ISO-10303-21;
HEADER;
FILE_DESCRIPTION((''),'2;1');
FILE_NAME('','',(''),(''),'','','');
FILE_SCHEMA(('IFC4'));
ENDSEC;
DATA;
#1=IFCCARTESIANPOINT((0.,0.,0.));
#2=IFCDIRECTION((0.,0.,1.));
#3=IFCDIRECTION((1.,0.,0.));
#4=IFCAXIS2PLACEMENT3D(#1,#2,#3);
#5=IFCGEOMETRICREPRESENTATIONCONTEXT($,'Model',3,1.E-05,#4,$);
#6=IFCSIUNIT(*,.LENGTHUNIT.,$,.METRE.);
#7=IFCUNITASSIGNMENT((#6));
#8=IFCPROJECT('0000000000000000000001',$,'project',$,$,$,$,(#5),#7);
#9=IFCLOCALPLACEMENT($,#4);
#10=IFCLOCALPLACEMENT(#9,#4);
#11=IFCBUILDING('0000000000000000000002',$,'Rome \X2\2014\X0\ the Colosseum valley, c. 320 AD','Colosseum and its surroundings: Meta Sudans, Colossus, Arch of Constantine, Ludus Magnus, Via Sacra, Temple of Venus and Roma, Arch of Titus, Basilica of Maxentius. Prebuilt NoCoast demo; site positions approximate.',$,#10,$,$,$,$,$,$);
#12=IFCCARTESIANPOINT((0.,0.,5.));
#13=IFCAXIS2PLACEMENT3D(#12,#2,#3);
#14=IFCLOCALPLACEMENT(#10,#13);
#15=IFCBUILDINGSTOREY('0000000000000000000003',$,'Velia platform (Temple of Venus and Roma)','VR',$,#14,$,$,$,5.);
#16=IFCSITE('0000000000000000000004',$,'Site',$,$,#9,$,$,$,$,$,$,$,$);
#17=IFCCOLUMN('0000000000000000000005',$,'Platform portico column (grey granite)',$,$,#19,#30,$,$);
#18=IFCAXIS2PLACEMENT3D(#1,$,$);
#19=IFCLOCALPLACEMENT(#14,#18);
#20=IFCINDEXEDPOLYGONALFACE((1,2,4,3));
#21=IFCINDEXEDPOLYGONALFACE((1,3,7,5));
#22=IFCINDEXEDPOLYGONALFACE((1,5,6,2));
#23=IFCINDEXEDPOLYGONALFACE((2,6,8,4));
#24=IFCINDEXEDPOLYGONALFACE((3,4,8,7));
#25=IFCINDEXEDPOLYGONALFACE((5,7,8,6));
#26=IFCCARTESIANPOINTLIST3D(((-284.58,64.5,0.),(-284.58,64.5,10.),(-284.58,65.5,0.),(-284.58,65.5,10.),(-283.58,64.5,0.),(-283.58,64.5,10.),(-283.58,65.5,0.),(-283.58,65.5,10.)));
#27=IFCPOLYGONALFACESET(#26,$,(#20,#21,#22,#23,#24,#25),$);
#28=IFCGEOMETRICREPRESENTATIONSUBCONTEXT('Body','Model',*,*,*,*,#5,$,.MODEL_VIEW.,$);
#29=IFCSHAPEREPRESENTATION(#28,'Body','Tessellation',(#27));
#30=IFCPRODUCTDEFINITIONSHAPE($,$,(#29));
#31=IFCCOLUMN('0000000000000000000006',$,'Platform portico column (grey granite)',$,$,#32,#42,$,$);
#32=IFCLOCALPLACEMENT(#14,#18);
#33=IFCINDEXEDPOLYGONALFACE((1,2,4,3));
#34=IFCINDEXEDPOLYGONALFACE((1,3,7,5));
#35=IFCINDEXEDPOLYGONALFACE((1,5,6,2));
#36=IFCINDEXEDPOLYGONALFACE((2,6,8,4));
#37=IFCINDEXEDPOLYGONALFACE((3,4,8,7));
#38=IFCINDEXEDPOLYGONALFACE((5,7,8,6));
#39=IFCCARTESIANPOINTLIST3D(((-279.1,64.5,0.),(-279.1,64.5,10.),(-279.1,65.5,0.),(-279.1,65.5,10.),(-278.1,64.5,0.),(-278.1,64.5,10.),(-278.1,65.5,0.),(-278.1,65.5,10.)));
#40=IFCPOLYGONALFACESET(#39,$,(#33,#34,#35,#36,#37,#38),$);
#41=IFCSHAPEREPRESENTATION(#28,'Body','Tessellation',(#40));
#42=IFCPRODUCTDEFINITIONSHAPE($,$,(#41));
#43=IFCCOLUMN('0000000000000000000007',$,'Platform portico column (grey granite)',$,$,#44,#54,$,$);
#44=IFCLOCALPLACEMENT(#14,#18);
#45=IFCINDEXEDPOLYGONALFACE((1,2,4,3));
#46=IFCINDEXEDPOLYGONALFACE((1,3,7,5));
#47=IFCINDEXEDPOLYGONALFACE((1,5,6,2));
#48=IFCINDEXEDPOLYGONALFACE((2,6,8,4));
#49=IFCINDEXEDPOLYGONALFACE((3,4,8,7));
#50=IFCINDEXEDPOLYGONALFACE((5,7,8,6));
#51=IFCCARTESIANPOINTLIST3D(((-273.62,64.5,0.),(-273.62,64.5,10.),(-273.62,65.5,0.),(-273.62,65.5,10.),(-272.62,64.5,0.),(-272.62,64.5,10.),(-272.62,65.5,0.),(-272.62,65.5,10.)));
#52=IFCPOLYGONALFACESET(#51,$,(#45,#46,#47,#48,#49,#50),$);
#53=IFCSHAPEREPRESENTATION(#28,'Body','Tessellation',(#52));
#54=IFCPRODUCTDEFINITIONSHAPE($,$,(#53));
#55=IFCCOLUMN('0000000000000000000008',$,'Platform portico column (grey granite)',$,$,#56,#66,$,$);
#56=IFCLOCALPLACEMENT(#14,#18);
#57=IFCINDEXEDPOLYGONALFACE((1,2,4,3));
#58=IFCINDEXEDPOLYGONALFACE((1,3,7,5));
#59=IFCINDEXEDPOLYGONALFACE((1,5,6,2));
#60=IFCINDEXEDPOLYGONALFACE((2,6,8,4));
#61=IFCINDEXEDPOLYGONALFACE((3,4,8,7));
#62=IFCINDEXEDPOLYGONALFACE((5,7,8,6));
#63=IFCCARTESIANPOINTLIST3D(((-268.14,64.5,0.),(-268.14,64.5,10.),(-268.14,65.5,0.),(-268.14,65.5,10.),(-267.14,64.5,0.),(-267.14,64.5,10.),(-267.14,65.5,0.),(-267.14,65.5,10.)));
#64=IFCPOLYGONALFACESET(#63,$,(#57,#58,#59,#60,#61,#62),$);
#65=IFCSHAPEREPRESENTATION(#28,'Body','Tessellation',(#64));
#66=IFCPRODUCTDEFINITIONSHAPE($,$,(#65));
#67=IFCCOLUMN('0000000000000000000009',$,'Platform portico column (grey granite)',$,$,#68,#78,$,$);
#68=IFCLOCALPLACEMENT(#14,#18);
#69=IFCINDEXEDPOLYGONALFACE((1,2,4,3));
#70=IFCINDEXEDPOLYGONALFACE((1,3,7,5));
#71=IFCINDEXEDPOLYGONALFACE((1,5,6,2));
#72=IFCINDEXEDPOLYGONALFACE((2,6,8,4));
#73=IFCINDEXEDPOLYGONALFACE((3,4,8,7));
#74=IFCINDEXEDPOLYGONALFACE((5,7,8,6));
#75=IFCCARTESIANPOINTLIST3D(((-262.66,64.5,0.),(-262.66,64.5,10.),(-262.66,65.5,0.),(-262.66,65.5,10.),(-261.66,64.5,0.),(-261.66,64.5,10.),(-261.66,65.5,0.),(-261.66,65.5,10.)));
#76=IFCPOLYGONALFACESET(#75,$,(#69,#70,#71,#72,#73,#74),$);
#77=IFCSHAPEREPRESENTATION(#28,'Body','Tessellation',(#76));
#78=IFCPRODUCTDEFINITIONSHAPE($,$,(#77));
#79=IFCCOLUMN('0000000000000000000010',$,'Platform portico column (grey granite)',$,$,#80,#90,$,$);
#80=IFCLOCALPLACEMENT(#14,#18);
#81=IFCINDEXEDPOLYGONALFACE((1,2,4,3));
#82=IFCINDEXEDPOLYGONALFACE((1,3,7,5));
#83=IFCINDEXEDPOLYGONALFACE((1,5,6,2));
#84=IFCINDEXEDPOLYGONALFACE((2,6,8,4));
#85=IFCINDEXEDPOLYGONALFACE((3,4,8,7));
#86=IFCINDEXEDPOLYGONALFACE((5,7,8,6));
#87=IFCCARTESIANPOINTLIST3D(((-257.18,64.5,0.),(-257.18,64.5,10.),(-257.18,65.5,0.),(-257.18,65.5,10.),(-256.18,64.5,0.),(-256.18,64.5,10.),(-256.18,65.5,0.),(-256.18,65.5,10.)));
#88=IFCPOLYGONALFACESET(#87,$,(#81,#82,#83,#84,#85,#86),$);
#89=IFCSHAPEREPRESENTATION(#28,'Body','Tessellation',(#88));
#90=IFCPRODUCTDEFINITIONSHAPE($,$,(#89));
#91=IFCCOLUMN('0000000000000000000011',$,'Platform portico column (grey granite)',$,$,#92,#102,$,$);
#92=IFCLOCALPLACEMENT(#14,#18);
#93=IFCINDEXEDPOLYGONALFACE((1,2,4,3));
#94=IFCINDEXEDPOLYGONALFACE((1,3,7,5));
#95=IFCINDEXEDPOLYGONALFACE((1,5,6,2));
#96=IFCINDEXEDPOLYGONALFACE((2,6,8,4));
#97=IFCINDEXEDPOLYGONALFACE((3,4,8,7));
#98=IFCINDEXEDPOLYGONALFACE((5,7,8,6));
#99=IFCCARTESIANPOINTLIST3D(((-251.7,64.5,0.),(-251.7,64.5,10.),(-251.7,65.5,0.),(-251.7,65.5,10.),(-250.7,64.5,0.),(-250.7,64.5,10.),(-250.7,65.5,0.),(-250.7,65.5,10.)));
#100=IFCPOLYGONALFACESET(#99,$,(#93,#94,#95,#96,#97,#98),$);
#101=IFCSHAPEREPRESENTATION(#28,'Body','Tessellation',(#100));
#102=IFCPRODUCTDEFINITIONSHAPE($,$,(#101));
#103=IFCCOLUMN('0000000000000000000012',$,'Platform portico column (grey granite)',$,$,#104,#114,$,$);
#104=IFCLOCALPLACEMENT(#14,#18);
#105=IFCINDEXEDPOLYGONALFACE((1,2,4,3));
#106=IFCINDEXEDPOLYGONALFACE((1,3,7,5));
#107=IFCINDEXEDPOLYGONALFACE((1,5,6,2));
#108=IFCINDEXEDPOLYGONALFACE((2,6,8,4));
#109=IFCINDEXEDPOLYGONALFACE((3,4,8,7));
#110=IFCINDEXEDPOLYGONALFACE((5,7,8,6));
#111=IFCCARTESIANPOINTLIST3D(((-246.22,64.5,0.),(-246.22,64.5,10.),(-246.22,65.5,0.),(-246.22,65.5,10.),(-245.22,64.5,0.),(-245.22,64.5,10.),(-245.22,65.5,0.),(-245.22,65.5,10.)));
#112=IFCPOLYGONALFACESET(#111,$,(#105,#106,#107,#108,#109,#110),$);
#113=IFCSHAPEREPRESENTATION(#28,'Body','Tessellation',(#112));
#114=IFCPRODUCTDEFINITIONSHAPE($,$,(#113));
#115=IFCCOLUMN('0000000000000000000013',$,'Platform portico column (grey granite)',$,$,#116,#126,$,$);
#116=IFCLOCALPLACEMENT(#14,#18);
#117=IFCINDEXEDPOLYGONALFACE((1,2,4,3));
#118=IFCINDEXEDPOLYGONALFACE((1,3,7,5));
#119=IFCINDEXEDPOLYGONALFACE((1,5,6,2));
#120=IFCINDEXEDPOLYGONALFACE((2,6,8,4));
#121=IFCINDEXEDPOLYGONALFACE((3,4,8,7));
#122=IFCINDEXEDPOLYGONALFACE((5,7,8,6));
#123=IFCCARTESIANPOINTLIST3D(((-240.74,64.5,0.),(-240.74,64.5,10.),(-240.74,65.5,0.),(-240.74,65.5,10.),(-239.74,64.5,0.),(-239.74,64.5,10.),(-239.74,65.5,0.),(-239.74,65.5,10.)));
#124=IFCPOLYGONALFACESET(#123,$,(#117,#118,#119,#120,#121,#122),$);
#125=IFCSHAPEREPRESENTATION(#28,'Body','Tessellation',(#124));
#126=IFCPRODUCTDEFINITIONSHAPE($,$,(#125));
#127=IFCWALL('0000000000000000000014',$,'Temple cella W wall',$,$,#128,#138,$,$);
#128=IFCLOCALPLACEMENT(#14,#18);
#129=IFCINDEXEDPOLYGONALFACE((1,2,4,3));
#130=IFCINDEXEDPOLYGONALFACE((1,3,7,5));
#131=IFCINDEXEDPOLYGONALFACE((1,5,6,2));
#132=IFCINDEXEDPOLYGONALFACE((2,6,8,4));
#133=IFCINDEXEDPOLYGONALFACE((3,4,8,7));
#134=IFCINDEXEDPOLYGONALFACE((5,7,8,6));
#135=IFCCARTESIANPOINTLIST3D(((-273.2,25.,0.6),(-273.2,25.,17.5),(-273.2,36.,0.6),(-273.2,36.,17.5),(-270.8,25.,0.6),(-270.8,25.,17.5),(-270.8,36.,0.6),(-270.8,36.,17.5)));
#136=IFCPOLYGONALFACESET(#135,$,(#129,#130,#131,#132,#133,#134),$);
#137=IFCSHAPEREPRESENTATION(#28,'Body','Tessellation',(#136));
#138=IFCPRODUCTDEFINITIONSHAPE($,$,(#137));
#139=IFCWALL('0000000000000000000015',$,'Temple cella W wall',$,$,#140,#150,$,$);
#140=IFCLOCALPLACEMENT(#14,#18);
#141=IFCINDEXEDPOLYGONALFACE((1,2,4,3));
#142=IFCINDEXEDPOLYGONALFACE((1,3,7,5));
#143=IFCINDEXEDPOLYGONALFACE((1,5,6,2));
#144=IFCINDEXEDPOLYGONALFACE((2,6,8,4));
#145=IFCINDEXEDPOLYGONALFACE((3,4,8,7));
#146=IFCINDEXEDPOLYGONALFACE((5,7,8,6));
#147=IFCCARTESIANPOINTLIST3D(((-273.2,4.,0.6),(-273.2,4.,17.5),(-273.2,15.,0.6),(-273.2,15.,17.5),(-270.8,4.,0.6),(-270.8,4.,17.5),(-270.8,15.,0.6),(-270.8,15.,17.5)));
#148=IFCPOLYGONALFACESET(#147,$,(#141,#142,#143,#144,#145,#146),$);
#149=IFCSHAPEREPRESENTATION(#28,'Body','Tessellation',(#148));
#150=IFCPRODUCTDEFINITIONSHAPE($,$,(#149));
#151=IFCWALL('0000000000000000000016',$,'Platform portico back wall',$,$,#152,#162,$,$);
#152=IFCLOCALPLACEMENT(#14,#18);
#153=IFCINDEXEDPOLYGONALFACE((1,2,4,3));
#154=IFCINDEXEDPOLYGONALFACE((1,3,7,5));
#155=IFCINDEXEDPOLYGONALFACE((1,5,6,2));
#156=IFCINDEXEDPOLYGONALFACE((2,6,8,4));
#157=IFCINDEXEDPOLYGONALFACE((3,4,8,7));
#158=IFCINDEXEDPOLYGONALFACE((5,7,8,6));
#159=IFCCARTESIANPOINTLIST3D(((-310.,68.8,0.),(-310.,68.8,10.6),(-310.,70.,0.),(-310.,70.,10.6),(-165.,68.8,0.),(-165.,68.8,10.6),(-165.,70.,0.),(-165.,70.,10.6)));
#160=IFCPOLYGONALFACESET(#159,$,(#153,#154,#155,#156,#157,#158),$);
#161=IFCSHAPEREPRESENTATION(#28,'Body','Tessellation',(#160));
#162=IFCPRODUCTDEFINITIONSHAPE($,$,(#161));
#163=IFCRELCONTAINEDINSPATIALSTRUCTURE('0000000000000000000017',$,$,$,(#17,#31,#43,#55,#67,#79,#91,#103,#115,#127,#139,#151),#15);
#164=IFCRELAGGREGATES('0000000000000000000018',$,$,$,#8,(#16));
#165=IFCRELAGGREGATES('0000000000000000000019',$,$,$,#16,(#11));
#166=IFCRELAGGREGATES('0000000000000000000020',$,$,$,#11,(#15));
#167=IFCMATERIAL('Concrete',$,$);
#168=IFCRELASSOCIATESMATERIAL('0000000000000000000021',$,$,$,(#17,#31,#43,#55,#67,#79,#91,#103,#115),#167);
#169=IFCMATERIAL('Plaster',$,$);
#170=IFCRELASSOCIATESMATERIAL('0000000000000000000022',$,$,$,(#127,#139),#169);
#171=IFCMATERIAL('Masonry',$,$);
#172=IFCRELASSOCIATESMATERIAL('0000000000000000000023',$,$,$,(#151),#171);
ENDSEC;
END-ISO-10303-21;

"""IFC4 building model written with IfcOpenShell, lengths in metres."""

from ifc_helpers import new_model, si_unit, frame, origin_with_axes, place, context, subcontext, project, spatial, indexed_curve, outline, extrude, material, element, save


model = new_model("IFC4")

# Units and contexts
model_context = context("Model", 3, precision=1e-05, world=origin_with_axes())
body_context = subcontext(model_context, "Body", "Model", "MODEL_VIEW")
ifc_project = project(units=[si_unit("LENGTHUNIT", "METRE")], contexts=[model_context])

# Site, building, storey
site_placement = place(None, origin_with_axes())
site = spatial("IfcSite", under=ifc_project, at=site_placement, Name="Site")
building_placement = place(site_placement, origin_with_axes())
building = spatial("IfcBuilding", under=site, at=building_placement, Name="Rome — the Colosseum valley, c. 320 AD", Description="Colosseum and its surroundings: Meta Sudans, Colossus, Arch of Constantine, Ludus Magnus, Via Sacra, Temple of Venus and Roma, Arch of Titus, Basilica of Maxentius. Prebuilt NoCoast demo; site positions approximate.")
storey_placement = place(building_placement, frame((0.0, 0.0, 5.0), z_axis=(0.0, 0.0, 1.0), x_axis=(1.0, 0.0, 0.0)))
storey = spatial("IfcBuildingStorey", under=building, at=storey_placement, Name="Velia platform (Temple of Venus and Roma)", Description="VR", Elevation=5.0)

# Columns
ifc_material_1 = material(Name="Concrete")
for number, where, z_axis, x_axis, name in (
    (1, (-284.58, 65.0, 0.0), (0.0, 0.0, 1.0), (1.0, 0.0, 0.0), "Platform portico column (grey granite)"),
    (2, (-279.1, 65.0, 0.0), (0.0, 0.0, 1.0), (1.0, 0.0, 0.0), "Platform portico column (grey granite)"),
    (3, (-273.62, 65.0, 0.0), (0.0, 0.0, 1.0), (1.0, 0.0, 0.0), "Platform portico column (grey granite)"),
    (4, (-268.14, 65.0, 0.0), (0.0, 0.0, 1.0), (1.0, 0.0, 0.0), "Platform portico column (grey granite)"),
    (5, (-262.66, 65.0, 0.0), (0.0, 0.0, 1.0), (1.0, 0.0, 0.0), "Platform portico column (grey granite)"),
    (6, (-257.18, 65.0, 0.0), (0.0, 0.0, 1.0), (1.0, 0.0, 0.0), "Platform portico column (grey granite)"),
    (7, (-251.7, 65.0, 0.0), (0.0, 0.0, 1.0), (1.0, 0.0, 0.0), "Platform portico column (grey granite)"),
    (8, (-246.22, 65.0, 0.0), (0.0, 0.0, 1.0), (1.0, 0.0, 0.0), "Platform portico column (grey granite)"),
    (9, (-240.74, 65.0, 0.0), (0.0, 0.0, 1.0), (1.0, 0.0, 0.0), "Platform portico column (grey granite)"),
):
    element("IfcColumn", number, at=place(storey_placement, frame(where, z_axis=z_axis, x_axis=x_axis)), inside=storey, material=ifc_material_1, Name=name, context=body_context, shape_type="SweptSolid", body=[
        extrude(outline(indexed_curve([(0.0, 0.0), (0.0, 1.0), (1.0, 1.0), (1.0, 0.0), (0.0, 0.0)], self_intersect=False)), frame((0.0, -0.5, 0.0), z_axis=(0.0, 0.0, 1.0), x_axis=(1.0, 0.0, 0.0)), (0.0, 0.0, 1.0), 10.0),
    ])

# Walls
ifc_material_2 = material(Name="Plaster")
for number, where, z_axis, x_axis, name in (
    (10, (-272.0, 36.0, 0.6), (0.0, 0.0, 1.0), (0.0, -1.0, 0.0), "Temple cella W wall"),
    (11, (-272.0, 15.0, 0.6), (0.0, 0.0, 1.0), (0.0, -1.0, 0.0), "Temple cella W wall"),
):
    element("IfcWall", number, at=place(storey_placement, frame(where, z_axis=z_axis, x_axis=x_axis)), inside=storey, material=ifc_material_2, Name=name, context=body_context, shape_type="SweptSolid", body=[
        extrude(outline(indexed_curve([(0.0, 0.0), (0.0, 2.4), (11.0, 2.4), (11.0, 0.0), (0.0, 0.0)], self_intersect=False)), frame((0.0, -1.2, 0.0), z_axis=(0.0, 0.0, 1.0), x_axis=(1.0, 0.0, 0.0)), (0.0, 0.0, 1.0), 16.9),
    ])
ifc_material_3 = material(Name="Masonry")
wall_placement = place(storey_placement, frame((-310.0, 69.4, 0.0), z_axis=(0.0, 0.0, 1.0), x_axis=(1.0, 0.0, 0.0)))
element("IfcWall", 12, at=wall_placement, inside=storey, material=ifc_material_3, Name="Platform portico back wall", context=body_context, shape_type="SweptSolid", body=[
    extrude(outline(indexed_curve([(0.0, 0.0), (0.0, 1.2), (145.0, 1.2), (145.0, 0.0), (0.0, 0.0)], self_intersect=False)), frame((0.0, -0.6, 0.0), z_axis=(0.0, 0.0, 1.0), x_axis=(1.0, 0.0, 0.0)), (0.0, 0.0, 1.0), 10.6),
])

save(model, "model.ifc")
